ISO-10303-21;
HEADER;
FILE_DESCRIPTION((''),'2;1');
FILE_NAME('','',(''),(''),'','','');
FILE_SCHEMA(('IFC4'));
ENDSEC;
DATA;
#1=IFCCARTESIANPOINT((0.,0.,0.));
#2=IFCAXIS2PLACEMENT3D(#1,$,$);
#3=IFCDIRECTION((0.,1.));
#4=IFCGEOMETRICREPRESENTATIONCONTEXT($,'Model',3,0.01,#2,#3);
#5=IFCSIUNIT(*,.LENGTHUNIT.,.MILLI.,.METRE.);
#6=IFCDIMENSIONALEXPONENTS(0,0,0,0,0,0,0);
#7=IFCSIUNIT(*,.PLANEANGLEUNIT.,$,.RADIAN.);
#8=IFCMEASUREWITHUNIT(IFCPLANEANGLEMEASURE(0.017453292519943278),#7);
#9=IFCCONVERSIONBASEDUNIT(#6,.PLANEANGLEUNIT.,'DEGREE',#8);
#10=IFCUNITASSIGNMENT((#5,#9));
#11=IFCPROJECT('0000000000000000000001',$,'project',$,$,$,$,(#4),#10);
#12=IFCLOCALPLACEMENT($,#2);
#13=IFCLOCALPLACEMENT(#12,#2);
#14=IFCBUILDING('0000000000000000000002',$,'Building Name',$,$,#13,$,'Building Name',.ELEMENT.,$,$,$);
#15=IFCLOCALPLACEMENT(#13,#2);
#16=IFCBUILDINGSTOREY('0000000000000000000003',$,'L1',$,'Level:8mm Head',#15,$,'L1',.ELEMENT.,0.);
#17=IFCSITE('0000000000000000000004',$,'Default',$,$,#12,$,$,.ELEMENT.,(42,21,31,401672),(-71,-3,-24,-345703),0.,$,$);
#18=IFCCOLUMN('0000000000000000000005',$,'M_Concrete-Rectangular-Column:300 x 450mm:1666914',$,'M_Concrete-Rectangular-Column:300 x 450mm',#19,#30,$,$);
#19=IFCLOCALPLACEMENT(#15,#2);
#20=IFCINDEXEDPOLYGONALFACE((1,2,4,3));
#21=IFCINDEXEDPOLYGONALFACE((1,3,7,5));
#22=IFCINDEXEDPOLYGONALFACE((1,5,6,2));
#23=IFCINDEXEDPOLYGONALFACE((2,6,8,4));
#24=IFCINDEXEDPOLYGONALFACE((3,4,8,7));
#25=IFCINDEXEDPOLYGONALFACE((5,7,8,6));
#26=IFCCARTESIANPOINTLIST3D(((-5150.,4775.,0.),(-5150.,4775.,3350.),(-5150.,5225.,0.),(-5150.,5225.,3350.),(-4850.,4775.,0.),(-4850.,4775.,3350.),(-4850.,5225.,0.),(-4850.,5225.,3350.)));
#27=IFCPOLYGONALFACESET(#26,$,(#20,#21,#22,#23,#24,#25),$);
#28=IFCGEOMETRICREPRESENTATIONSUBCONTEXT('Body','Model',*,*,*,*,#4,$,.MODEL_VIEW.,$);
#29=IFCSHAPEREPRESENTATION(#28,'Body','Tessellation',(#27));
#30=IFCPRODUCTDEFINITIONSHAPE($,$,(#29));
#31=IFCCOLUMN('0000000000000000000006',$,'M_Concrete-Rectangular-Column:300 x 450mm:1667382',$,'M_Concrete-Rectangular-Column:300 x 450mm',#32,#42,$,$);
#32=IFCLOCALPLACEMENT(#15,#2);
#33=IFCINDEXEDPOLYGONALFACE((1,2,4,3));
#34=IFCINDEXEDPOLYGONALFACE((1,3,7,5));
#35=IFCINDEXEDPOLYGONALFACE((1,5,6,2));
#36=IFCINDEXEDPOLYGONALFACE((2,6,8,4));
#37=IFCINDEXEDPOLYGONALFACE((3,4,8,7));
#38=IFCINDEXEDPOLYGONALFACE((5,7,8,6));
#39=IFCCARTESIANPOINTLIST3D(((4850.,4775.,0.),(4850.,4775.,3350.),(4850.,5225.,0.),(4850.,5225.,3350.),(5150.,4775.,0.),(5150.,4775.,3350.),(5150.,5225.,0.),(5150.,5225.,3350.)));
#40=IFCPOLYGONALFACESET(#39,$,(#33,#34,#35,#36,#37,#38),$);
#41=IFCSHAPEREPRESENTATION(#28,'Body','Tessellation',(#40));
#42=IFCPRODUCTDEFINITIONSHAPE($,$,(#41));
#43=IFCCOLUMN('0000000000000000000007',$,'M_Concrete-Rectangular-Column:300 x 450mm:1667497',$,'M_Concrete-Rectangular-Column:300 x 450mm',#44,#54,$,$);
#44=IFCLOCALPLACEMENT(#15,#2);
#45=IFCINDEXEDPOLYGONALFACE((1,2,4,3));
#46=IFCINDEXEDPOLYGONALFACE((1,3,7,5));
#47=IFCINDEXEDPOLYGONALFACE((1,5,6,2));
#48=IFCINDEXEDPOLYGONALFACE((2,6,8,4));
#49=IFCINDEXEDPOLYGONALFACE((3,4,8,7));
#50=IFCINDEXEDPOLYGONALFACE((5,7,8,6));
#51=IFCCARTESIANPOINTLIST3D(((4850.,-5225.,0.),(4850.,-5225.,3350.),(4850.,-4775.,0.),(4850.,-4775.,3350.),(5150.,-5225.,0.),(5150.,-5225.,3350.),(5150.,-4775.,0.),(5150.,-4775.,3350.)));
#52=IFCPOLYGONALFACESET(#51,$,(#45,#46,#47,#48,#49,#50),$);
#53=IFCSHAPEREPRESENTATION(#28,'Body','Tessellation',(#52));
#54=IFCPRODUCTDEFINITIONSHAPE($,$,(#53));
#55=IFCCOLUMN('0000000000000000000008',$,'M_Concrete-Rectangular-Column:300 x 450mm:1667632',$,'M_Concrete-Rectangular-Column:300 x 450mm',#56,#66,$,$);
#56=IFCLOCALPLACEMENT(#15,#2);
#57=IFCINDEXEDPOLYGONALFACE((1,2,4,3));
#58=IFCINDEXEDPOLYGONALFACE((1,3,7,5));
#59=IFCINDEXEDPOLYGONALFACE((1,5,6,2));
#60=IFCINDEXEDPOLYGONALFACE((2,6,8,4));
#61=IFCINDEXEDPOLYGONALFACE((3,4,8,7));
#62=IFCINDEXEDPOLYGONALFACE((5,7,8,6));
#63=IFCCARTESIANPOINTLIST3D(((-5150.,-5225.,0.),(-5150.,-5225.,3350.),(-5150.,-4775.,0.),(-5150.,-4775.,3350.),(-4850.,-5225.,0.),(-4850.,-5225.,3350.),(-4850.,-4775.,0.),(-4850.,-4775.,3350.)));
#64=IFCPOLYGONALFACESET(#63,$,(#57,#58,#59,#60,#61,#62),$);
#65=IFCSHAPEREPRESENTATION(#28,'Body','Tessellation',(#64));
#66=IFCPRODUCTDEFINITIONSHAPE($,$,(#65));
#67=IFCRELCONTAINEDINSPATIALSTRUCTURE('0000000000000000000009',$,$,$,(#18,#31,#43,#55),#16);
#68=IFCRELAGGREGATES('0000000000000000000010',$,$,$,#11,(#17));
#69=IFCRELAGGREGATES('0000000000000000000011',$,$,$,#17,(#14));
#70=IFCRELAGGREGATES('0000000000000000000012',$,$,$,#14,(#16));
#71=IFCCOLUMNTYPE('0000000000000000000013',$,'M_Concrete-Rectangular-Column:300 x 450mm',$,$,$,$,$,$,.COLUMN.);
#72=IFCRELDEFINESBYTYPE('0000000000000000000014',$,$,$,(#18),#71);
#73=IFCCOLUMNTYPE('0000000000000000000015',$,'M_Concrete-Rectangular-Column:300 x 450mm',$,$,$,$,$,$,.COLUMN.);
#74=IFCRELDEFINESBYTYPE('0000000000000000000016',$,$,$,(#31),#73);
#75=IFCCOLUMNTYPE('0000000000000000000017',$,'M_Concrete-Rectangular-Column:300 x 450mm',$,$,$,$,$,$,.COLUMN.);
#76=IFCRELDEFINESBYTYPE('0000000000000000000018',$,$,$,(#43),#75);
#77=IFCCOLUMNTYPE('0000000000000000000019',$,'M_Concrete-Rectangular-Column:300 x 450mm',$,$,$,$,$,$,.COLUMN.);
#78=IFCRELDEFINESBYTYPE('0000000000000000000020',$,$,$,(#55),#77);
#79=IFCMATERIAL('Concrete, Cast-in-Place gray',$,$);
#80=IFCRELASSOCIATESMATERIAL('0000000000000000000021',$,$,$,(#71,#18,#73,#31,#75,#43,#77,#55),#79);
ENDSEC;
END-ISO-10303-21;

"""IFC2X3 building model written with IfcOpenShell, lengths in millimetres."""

from ifc_helpers import new_model, entity, si_unit, converted_unit, direction, frame, frame_2d, origin, place, context, subcontext, project, spatial, rectangle, extrude, source, transform, mapped, material, type_object, type_shapes, element, save


model = new_model("IFC2X3")

# Units and contexts
model_context = context("Model", 3, precision=0.01, world=origin(), true_north=direction((0.0, 1.0)))
body_context = subcontext(model_context, "Body", "Model", "MODEL_VIEW")
ifc_project = project(units=[si_unit("LENGTHUNIT", "METRE", prefix="MILLI"), converted_unit("PLANEANGLEUNIT", "DEGREE", entity("IfcPlaneAngleMeasure", 0.017453292519943278), si_unit("PLANEANGLEUNIT", "RADIAN"), dimensions=[0, 0, 0, 0, 0, 0, 0])], contexts=[model_context])

# Site, building, storey
site_placement = place(None, origin())
site = spatial("IfcSite", under=ifc_project, at=site_placement, Name="Default", CompositionType="ELEMENT", RefLatitude=(42, 21, 31, 401672), RefLongitude=(-71, -3, -24, -345703), RefElevation=0.0)
building_placement = place(site_placement, origin())
building = spatial("IfcBuilding", under=site, at=building_placement, Name="Building Name", LongName="Building Name", CompositionType="ELEMENT")
storey_placement = place(building_placement, origin())
storey = spatial("IfcBuildingStorey", under=building, at=storey_placement, Name="L1", ObjectType="Level:8mm Head", LongName="L1", CompositionType="ELEMENT", Elevation=0.0)

# Columns
ifc_material = material(Name="Concrete, Cast-in-Place gray")
column_type_1 = type_object("IfcColumnType", Name="M_Concrete-Rectangular-Column:300 x 450mm", PredefinedType="COLUMN", material=ifc_material)
shared_shape_1 = source(origin(), body_context, "Body", "SweptSolid", [
    extrude(rectangle(XDim=3350.0, YDim=450.0, at=frame_2d((0.0, 0.0), x_axis=(1.0, 0.0))), frame((-5150.0, 5000.0, 1675.0), z_axis=(1.0, 0.0, 0.0), x_axis=(0.0, 0.0, 1.0)), (0.0, 0.0, 1.0), 300.0),
])
type_shapes(column_type_1, [shared_shape_1])
column_1_placement = place(storey_placement, origin())
element("IfcColumn", 1, at=column_1_placement, inside=storey, type_object=column_type_1, material=ifc_material, Name="M_Concrete-Rectangular-Column:300 x 450mm:1666914", ObjectType="M_Concrete-Rectangular-Column:300 x 450mm", context=body_context, shape_type="MappedRepresentation", body=[
    mapped(shared_shape_1, transform((0.0, 0.0, 0.0), scale=1.0)),
])
column_type_2 = type_object("IfcColumnType", Name="M_Concrete-Rectangular-Column:300 x 450mm", PredefinedType="COLUMN", material=ifc_material)
shared_shape_2 = source(origin(), body_context, "Body", "SweptSolid", [
    extrude(rectangle(XDim=3350.0, YDim=450.0, at=frame_2d((0.0, 0.0), x_axis=(1.0, 0.0))), frame((4850.0, 5000.0, 1675.0), z_axis=(1.0, 0.0, 0.0), x_axis=(0.0, 0.0, 1.0)), (0.0, 0.0, 1.0), 300.0),
])
type_shapes(column_type_2, [shared_shape_2])
column_2_placement = place(storey_placement, origin())
element("IfcColumn", 2, at=column_2_placement, inside=storey, type_object=column_type_2, material=ifc_material, Name="M_Concrete-Rectangular-Column:300 x 450mm:1667382", ObjectType="M_Concrete-Rectangular-Column:300 x 450mm", context=body_context, shape_type="MappedRepresentation", body=[
    mapped(shared_shape_2, transform((0.0, 0.0, 0.0), scale=1.0)),
])
column_type_3 = type_object("IfcColumnType", Name="M_Concrete-Rectangular-Column:300 x 450mm", PredefinedType="COLUMN", material=ifc_material)
shared_shape_3 = source(origin(), body_context, "Body", "SweptSolid", [
    extrude(rectangle(XDim=3350.0, YDim=450.0, at=frame_2d((0.0, 0.0), x_axis=(1.0, 0.0))), frame((4850.0, -5000.0, 1675.0), z_axis=(1.0, 0.0, 0.0), x_axis=(0.0, 0.0, 1.0)), (0.0, 0.0, 1.0), 300.0),
])
type_shapes(column_type_3, [shared_shape_3])
column_3_placement = place(storey_placement, origin())
element("IfcColumn", 3, at=column_3_placement, inside=storey, type_object=column_type_3, material=ifc_material, Name="M_Concrete-Rectangular-Column:300 x 450mm:1667497", ObjectType="M_Concrete-Rectangular-Column:300 x 450mm", context=body_context, shape_type="MappedRepresentation", body=[
    mapped(shared_shape_3, transform((0.0, 0.0, 0.0), scale=1.0)),
])
column_type_4 = type_object("IfcColumnType", Name="M_Concrete-Rectangular-Column:300 x 450mm", PredefinedType="COLUMN", material=ifc_material)
shared_shape_4 = source(origin(), body_context, "Body", "SweptSolid", [
    extrude(rectangle(XDim=3350.0, YDim=450.0, at=frame_2d((0.0, 0.0), x_axis=(1.0, 0.0))), frame((-5150.0, -5000.0, 1675.0), z_axis=(1.0, 0.0, 0.0), x_axis=(0.0, 0.0, 1.0)), (0.0, 0.0, 1.0), 300.0),
])
type_shapes(column_type_4, [shared_shape_4])
column_4_placement = place(storey_placement, origin())
element("IfcColumn", 4, at=column_4_placement, inside=storey, type_object=column_type_4, material=ifc_material, Name="M_Concrete-Rectangular-Column:300 x 450mm:1667632", ObjectType="M_Concrete-Rectangular-Column:300 x 450mm", context=body_context, shape_type="MappedRepresentation", body=[
    mapped(shared_shape_4, transform((0.0, 0.0, 0.0), scale=1.0)),
])

save(model, "model.ifc")
